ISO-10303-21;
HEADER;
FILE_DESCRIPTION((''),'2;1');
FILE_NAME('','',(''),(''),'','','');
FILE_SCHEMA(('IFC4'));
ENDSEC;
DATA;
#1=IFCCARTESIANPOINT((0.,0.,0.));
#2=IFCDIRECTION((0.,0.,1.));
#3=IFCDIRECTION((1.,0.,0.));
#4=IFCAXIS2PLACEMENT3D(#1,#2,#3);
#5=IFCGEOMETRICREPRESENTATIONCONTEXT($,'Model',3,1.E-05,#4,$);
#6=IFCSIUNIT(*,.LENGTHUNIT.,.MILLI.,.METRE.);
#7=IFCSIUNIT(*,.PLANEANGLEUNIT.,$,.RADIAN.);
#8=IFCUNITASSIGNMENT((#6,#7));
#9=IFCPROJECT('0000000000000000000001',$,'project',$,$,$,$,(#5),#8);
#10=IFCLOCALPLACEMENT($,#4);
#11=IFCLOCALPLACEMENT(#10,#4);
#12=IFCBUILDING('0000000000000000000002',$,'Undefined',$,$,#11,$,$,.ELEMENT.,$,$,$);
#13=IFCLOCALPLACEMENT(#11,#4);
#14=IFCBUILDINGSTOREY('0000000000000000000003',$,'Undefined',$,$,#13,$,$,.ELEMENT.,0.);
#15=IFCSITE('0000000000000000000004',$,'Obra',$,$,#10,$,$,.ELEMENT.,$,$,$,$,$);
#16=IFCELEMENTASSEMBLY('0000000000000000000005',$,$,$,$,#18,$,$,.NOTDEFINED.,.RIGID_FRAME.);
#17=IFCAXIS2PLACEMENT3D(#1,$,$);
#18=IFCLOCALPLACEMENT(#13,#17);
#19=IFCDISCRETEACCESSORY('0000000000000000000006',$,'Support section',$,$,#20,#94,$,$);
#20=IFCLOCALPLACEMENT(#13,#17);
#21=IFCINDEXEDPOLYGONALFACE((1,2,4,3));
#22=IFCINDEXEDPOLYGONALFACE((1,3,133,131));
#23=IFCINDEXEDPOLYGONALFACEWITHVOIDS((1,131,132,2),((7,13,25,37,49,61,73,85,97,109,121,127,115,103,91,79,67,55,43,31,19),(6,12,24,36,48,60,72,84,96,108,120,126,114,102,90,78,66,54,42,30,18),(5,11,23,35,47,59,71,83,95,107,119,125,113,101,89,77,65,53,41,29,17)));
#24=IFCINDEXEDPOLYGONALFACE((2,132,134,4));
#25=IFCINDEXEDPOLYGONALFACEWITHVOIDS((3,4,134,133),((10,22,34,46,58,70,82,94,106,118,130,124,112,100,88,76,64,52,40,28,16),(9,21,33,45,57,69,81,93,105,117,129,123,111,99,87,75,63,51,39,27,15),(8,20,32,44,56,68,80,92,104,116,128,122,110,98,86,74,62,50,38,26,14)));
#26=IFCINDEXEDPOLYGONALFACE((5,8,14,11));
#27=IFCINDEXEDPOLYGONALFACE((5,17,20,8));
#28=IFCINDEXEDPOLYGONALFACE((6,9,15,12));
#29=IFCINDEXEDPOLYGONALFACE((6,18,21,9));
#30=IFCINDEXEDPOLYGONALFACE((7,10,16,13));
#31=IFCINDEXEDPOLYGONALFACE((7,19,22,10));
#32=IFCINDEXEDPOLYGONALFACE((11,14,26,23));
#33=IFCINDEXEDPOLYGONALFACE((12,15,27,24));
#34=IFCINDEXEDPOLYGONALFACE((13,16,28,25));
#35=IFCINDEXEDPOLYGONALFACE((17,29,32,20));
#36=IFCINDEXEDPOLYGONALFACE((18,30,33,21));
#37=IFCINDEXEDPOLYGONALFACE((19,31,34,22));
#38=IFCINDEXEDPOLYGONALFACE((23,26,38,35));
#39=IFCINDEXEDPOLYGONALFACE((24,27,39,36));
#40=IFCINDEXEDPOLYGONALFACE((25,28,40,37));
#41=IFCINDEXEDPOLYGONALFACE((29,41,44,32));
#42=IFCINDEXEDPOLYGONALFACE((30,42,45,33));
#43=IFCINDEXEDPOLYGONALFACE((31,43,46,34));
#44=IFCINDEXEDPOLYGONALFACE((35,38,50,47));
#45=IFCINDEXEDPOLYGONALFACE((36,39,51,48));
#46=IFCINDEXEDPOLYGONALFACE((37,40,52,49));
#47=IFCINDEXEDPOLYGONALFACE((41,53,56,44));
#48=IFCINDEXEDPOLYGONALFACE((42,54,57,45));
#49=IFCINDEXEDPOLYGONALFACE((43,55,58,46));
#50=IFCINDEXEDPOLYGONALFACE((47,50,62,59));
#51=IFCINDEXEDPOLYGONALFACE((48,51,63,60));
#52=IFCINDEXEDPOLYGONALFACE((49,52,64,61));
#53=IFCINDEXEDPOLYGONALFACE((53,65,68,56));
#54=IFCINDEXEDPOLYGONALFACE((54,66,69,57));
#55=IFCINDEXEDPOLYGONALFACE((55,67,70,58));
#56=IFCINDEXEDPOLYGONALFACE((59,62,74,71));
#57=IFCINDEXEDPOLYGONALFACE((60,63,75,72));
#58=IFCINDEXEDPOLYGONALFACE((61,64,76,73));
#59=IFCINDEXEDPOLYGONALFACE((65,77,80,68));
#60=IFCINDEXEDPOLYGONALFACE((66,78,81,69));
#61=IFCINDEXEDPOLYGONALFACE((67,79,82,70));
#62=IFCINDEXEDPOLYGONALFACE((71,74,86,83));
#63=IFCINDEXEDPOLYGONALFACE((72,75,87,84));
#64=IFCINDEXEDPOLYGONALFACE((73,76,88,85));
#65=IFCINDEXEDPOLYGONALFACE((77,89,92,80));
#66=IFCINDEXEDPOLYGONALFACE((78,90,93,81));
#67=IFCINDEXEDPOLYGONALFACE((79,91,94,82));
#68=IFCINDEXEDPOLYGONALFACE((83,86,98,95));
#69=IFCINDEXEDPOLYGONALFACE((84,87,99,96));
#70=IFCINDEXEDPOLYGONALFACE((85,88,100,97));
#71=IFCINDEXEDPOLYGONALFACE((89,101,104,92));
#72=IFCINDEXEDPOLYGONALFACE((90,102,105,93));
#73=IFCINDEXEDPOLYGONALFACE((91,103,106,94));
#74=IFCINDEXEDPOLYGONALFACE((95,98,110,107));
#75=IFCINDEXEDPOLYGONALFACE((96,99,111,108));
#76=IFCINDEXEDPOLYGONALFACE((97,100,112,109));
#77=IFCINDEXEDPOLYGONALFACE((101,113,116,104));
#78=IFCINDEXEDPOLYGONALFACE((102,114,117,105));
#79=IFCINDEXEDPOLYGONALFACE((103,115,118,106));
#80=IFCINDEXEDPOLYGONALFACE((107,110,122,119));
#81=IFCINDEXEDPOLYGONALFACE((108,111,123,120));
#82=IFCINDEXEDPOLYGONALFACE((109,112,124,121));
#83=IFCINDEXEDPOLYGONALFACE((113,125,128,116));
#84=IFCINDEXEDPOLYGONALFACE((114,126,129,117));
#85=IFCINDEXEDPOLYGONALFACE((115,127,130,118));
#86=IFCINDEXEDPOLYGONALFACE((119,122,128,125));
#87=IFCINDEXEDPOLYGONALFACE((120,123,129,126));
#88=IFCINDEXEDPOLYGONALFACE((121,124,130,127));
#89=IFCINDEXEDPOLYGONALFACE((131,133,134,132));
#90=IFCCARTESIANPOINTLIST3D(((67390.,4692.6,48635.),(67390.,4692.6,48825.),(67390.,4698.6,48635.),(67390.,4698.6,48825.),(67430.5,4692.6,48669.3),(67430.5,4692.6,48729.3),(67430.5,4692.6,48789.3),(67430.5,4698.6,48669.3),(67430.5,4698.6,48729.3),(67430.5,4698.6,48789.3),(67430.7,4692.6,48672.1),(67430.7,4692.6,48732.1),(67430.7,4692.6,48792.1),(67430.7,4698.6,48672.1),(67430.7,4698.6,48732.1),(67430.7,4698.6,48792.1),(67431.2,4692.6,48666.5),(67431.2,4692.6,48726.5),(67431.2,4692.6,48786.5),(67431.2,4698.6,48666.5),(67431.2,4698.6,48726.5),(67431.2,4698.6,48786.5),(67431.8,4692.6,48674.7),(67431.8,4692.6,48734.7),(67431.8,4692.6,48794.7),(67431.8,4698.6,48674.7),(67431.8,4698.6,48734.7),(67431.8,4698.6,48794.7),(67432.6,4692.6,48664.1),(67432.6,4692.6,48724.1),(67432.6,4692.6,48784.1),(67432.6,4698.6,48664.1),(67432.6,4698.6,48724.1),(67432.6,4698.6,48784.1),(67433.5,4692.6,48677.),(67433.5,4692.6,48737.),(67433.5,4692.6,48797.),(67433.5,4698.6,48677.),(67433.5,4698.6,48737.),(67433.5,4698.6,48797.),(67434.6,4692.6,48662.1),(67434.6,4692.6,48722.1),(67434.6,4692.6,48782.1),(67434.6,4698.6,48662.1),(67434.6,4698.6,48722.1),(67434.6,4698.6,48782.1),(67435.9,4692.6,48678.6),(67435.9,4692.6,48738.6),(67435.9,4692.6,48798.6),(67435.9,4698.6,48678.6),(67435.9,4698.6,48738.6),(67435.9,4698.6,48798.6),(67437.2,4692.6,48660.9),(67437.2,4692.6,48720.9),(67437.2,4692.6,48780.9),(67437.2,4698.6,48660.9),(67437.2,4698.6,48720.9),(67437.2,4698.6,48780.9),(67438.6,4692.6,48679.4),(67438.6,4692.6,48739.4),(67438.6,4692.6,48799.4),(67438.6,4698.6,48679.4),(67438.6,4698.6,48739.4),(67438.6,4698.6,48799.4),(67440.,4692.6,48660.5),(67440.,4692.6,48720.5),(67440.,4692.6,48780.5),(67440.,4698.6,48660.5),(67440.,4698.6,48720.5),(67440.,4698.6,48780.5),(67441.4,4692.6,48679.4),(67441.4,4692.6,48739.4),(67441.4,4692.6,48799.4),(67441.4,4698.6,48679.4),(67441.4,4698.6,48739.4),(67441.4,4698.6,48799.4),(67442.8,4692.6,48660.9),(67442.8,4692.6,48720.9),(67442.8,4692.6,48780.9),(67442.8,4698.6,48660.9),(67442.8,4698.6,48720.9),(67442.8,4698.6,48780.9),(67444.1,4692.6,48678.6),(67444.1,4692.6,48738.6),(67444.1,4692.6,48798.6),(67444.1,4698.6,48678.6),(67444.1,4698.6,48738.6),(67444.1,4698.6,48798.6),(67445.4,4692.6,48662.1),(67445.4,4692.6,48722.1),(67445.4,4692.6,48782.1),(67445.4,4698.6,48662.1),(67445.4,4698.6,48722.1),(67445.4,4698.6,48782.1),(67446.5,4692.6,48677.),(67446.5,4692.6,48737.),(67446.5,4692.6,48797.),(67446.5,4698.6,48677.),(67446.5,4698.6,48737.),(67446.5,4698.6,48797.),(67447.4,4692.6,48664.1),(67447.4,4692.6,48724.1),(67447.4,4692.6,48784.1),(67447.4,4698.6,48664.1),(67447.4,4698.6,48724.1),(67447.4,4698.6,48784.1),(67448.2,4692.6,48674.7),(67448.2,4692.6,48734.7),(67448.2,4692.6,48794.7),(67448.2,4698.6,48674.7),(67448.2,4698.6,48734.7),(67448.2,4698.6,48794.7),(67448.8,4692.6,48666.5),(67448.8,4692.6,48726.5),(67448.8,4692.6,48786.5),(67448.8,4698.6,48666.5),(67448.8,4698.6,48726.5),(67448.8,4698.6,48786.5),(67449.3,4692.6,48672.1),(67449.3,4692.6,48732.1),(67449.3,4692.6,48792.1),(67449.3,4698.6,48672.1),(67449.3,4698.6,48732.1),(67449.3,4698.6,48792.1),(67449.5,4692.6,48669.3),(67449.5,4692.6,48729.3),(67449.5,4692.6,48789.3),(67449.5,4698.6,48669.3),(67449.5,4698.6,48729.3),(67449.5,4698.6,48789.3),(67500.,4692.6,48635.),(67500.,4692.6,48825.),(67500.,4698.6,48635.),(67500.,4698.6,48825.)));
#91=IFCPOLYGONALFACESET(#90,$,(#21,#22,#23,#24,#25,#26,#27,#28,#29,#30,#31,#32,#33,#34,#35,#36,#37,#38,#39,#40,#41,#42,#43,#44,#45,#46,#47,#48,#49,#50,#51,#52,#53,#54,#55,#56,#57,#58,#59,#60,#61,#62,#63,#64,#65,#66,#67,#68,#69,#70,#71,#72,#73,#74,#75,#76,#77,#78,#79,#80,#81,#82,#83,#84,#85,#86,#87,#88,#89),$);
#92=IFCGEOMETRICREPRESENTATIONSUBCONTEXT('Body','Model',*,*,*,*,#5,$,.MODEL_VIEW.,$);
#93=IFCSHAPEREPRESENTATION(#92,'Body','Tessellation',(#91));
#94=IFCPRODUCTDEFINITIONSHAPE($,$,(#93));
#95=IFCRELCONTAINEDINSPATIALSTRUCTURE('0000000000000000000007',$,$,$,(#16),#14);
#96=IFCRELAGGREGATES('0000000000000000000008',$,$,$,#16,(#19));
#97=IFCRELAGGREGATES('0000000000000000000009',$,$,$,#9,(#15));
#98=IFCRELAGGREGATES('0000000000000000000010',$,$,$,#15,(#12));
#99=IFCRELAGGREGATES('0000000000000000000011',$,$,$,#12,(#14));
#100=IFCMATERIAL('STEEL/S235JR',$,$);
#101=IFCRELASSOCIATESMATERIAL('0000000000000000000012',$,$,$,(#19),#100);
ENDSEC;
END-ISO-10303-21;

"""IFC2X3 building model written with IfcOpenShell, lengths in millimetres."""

from ifc_helpers import new_model, si_unit, frame, origin_with_axes, origin_2d_with_axis, place, context, subcontext, project, spatial, rectangle, circle, extrude, source, transform, mapped, material, element, aggregate, save


model = new_model("IFC2X3")

# Units and contexts
model_context = context("Model", 3, precision=1e-05, world=origin_with_axes())
body_context = subcontext(model_context, "Body", "Model", "MODEL_VIEW")
ifc_project = project(units=[si_unit("LENGTHUNIT", "METRE", prefix="MILLI"), si_unit("PLANEANGLEUNIT", "RADIAN")], contexts=[model_context])

# Site, building, storey
site_placement = place(None, origin_with_axes())
site = spatial("IfcSite", under=ifc_project, at=site_placement, Name="Obra", CompositionType="ELEMENT")
building_placement = place(site_placement, origin_with_axes())
building = spatial("IfcBuilding", under=site, at=building_placement, Name="Undefined", CompositionType="ELEMENT")
storey_placement = place(building_placement, origin_with_axes())
storey = spatial("IfcBuildingStorey", under=building, at=storey_placement, Name="Undefined", CompositionType="ELEMENT", Elevation=0.0)

# Element assembly
ifc_material_1 = material(Name="STEEL/S235JR")
assembly_1_placement = place(storey_placement, origin_with_axes())
assembly_1 = element("IfcElementAssembly", 1, at=assembly_1_placement, inside=storey, AssemblyPlace="NOTDEFINED", PredefinedType="RIGID_FRAME")

# Discrete accessory, opening
shared_shape_1 = source(origin_with_axes(), body_context, "Body", "SweptSolid", [
    extrude(circle(Radius=9.5, at=origin_2d_with_axis()), frame((0.0, -9.2, 0.0), z_axis=(0.0, 1.0, 0.0), x_axis=(1.0, 0.0, 0.0)), (0.0, 0.0, 1.0), 6.2),
])
discrete_accessory_1_placement = place(assembly_1_placement, frame((67445.0, 4695.6, 48635.0), z_axis=(0.0, 0.0, 1.0), x_axis=(1.0, 0.0, 0.0)))
discrete_accessory_1 = element("IfcDiscreteAccessory", 2, at=discrete_accessory_1_placement, material=ifc_material_1, Name="Support section", context=body_context, shape_type="SweptSolid", body=[
    extrude(rectangle(XDim=6.0, YDim=110.0, at=origin_2d_with_axis()), frame((0.0, 0.0, 190.0), z_axis=(0.0, 0.0, -1.0), x_axis=(0.0, 1.0, 0.0)), (0.0, 0.0, 1.0), 190.0),
])
opening_1_placement = place(assembly_1_placement, frame((67490.0, 4689.5, 48850.0), z_axis=(-1.0, 0.0, 0.0), x_axis=(0.0, 0.0, -1.0)))
element("IfcOpeningElement", 3, at=opening_1_placement, cuts=discrete_accessory_1, ObjectType="Opening", context=body_context, shape_type="MappedRepresentation", body=[
    mapped(shared_shape_1, transform((60.0, 0.0, 50.0))),
    mapped(shared_shape_1, transform((120.0, 0.0, 50.0))),
    mapped(shared_shape_1, transform((180.0, 0.0, 50.0))),
])
aggregate(assembly_1, [discrete_accessory_1])

save(model, "model.ifc")
